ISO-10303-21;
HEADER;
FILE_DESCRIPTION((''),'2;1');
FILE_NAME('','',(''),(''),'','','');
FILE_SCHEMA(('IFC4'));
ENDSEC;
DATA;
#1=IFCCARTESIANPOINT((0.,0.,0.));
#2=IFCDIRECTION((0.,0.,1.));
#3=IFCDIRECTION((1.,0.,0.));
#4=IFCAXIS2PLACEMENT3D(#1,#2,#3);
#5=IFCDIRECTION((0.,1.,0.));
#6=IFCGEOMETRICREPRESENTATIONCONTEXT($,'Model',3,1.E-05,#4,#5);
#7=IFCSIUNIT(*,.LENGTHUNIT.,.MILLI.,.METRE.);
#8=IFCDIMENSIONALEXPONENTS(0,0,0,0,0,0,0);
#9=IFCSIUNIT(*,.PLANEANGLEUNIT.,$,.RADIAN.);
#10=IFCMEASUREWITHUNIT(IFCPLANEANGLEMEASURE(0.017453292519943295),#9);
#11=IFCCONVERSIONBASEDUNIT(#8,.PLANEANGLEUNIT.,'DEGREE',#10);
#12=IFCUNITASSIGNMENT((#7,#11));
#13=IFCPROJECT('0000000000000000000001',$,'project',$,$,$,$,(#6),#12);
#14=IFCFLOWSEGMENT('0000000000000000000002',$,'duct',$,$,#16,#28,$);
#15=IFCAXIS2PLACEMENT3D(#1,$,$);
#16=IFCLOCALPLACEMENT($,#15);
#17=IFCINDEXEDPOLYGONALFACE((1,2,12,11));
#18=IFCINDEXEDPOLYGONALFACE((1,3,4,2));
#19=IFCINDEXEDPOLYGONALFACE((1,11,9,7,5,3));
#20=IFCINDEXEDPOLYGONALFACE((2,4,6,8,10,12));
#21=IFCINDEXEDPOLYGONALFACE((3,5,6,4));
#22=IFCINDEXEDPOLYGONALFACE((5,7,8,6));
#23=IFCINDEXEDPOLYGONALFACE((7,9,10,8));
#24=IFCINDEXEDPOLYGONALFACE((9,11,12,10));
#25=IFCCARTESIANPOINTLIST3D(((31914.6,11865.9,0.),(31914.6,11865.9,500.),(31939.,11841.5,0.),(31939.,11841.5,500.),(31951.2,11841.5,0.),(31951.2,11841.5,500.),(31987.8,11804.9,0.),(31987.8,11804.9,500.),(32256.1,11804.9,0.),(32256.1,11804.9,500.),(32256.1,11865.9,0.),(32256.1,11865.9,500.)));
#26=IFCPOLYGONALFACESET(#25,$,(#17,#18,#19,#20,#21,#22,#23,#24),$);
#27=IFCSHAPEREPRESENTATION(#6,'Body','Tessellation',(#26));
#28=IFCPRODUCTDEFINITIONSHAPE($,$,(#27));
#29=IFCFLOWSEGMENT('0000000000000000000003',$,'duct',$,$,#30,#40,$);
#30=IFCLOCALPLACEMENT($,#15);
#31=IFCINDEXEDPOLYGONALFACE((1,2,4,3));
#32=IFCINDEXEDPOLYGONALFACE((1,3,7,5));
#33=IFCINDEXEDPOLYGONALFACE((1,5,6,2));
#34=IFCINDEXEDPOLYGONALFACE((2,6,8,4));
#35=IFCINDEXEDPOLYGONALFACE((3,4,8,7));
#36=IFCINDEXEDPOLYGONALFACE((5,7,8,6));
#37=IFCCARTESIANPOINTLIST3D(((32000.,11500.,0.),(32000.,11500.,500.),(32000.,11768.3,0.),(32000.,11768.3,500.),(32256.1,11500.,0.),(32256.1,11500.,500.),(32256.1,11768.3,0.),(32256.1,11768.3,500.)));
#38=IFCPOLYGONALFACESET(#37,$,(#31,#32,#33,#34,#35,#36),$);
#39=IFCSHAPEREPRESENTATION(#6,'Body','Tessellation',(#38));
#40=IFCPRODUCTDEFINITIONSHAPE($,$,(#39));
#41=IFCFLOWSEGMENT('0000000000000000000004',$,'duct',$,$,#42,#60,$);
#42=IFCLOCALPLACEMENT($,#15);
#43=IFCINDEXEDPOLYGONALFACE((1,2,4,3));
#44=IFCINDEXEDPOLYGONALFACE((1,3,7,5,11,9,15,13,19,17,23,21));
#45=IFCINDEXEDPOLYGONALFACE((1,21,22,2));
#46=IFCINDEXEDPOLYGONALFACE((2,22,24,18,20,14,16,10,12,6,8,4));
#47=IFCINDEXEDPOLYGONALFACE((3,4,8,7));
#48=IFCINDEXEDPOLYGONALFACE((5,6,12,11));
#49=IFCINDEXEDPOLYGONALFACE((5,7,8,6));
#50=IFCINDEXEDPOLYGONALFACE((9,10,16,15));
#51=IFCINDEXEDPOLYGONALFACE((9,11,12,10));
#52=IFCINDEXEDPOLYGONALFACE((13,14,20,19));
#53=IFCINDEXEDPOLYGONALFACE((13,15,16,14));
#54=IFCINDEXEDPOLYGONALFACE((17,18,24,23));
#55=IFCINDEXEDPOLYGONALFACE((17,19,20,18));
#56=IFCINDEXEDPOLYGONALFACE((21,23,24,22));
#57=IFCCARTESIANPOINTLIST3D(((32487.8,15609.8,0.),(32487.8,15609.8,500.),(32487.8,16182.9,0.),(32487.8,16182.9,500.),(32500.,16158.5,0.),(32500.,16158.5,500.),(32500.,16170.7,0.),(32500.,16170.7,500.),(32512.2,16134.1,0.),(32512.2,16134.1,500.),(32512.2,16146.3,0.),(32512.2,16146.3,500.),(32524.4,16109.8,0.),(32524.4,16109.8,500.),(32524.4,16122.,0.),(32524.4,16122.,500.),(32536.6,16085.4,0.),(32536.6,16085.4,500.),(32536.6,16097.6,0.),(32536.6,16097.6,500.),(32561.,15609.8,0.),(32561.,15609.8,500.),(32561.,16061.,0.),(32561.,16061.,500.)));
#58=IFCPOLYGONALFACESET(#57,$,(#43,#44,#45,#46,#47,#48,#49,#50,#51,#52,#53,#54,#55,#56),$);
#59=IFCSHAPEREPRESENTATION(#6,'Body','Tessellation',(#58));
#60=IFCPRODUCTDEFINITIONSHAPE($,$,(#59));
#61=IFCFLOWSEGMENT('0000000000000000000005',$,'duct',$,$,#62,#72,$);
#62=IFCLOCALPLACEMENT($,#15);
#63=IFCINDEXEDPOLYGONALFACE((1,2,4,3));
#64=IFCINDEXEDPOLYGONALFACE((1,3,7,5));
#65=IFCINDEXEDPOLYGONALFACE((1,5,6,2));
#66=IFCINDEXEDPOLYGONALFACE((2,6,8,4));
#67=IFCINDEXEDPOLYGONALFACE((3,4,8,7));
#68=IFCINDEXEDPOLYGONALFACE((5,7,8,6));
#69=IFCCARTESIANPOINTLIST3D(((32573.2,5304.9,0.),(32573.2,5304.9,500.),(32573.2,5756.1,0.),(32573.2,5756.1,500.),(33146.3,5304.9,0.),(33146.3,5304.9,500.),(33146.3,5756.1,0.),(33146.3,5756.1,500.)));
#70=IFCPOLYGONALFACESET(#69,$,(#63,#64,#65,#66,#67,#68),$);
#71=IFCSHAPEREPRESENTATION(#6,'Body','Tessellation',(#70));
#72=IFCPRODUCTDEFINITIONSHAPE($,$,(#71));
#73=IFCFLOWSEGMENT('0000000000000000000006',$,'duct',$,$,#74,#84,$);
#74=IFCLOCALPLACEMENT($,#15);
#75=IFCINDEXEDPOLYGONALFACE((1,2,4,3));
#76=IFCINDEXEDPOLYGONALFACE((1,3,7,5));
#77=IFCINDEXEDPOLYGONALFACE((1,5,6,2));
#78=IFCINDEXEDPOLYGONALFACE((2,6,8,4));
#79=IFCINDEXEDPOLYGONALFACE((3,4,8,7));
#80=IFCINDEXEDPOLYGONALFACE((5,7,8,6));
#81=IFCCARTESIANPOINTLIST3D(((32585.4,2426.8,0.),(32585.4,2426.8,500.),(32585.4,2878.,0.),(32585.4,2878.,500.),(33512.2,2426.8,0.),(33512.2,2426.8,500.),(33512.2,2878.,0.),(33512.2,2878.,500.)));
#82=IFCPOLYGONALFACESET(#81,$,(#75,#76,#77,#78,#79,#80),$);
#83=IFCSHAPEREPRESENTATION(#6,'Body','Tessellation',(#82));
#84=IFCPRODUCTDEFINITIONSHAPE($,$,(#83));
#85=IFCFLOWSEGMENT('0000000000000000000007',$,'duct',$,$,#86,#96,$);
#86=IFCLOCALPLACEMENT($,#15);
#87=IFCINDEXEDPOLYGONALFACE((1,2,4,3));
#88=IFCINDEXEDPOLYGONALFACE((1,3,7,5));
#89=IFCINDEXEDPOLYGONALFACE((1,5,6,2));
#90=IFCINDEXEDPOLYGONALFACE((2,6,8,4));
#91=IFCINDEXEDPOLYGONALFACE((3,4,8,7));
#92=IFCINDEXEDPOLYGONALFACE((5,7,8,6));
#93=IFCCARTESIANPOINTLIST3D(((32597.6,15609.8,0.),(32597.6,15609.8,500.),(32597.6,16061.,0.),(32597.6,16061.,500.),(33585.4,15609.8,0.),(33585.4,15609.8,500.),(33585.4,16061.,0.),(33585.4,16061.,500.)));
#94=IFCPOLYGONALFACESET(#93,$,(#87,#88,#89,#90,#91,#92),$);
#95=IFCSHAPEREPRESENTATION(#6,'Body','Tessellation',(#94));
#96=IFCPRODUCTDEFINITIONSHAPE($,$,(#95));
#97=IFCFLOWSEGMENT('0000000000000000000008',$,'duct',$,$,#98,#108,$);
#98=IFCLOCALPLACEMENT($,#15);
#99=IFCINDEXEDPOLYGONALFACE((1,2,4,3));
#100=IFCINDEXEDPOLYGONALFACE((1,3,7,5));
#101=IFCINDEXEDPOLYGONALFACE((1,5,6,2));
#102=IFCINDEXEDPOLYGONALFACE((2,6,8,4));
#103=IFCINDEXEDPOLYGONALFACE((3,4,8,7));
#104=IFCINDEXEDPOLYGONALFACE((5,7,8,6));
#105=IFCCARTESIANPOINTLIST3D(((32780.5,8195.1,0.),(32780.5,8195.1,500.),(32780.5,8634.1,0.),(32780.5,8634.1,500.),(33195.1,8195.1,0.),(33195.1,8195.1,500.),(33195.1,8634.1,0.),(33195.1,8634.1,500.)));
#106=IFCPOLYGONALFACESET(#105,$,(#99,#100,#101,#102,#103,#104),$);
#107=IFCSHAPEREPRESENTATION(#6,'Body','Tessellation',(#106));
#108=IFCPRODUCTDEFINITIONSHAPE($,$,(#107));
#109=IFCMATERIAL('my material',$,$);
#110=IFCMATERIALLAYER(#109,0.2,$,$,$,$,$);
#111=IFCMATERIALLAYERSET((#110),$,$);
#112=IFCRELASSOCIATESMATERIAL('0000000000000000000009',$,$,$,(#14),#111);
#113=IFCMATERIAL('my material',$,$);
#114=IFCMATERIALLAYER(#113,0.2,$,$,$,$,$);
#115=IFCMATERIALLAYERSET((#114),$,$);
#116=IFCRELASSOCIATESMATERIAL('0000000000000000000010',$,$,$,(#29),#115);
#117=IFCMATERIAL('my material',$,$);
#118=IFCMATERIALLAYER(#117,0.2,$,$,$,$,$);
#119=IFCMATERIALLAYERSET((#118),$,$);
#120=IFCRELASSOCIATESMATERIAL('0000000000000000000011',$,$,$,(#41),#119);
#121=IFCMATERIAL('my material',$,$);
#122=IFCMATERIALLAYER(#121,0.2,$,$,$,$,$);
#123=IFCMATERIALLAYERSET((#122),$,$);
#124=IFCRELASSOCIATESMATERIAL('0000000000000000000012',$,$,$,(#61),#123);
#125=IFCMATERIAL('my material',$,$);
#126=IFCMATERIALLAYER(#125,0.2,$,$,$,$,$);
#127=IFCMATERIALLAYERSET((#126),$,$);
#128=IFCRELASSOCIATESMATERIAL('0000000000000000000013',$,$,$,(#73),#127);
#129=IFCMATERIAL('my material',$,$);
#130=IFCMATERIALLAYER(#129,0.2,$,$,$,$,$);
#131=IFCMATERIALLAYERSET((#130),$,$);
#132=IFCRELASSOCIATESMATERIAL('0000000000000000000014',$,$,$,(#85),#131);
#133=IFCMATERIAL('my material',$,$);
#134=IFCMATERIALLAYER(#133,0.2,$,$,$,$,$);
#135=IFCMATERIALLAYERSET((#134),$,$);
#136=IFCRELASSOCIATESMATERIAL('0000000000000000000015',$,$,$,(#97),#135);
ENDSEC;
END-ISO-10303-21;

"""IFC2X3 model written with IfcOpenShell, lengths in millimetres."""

from ifc_helpers import new_model, entity, si_unit, converted_unit, direction, origin_with_axes, place, context, project, polyline, outline, extrude, material, layer, layer_set, layer_usage, element, save


model = new_model("IFC2X3")

# Units and contexts
model_context = context("Model", 3, precision=1e-05, world=origin_with_axes(), true_north=direction((0.0, 1.0, 0.0)))
ifc_project = project(units=[si_unit("LENGTHUNIT", "METRE", prefix="MILLI"), converted_unit("PLANEANGLEUNIT", "DEGREE", entity("IfcPlaneAngleMeasure", 0.017453292519943295), si_unit("PLANEANGLEUNIT", "RADIAN"), dimensions=[0, 0, 0, 0, 0, 0, 0])], contexts=[model_context])

# Flow segments
ifc_material_1 = material(Name="my material")
ifc_layer_1 = layer(ifc_material_1, 0.2)
ifc_layer_set_1 = layer_set([ifc_layer_1])
ifc_layer_usage_1 = layer_usage(ifc_layer_set_1, "AXIS2", "POSITIVE", -0.1)
flow_segment_1_placement = place(None, origin_with_axes())
element("IfcFlowSegment", 1, at=flow_segment_1_placement, material=ifc_layer_usage_1, Name="duct", context=model_context, shape_type="SweptSolid", body=[
    extrude(outline(polyline([(31914.6, 11865.9), (31939.0, 11841.5), (31951.2, 11841.5), (31987.8, 11804.9), (32256.1, 11804.9), (32256.1, 11865.9), (31914.6, 11865.9)])), origin_with_axes(), (0.0, 0.0, 1.0), 500.0),
])
ifc_material_2 = material(Name="my material")
ifc_layer_2 = layer(ifc_material_2, 0.2)
ifc_layer_set_2 = layer_set([ifc_layer_2])
ifc_layer_usage_2 = layer_usage(ifc_layer_set_2, "AXIS2", "POSITIVE", -0.1)
flow_segment_2_placement = place(None, origin_with_axes())
element("IfcFlowSegment", 2, at=flow_segment_2_placement, material=ifc_layer_usage_2, Name="duct", context=model_context, shape_type="SweptSolid", body=[
    extrude(outline(polyline([(32000.0, 11500.0), (32256.1, 11500.0), (32256.1, 11768.3), (32000.0, 11768.3), (32000.0, 11500.0)])), origin_with_axes(), (0.0, 0.0, 1.0), 500.0),
])
ifc_material_3 = material(Name="my material")
ifc_layer_3 = layer(ifc_material_3, 0.2)
ifc_layer_set_3 = layer_set([ifc_layer_3])
ifc_layer_usage_3 = layer_usage(ifc_layer_set_3, "AXIS2", "POSITIVE", -0.1)
flow_segment_3_placement = place(None, origin_with_axes())
element("IfcFlowSegment", 3, at=flow_segment_3_placement, material=ifc_layer_usage_3, Name="duct", context=model_context, shape_type="SweptSolid", body=[
    extrude(outline(polyline([(32487.8, 15609.8), (32561.0, 15609.8), (32561.0, 16061.0), (32536.6, 16085.4), (32536.6, 16097.6), (32524.4, 16109.8), (32524.4, 16122.0), (32512.2, 16134.1), (32512.2, 16146.3), (32500.0, 16158.5), (32500.0, 16170.7), (32487.8, 16182.9), (32487.8, 16195.1), (32487.8, 15609.8)])), origin_with_axes(), (0.0, 0.0, 1.0), 500.0),
])
ifc_material_4 = material(Name="my material")
ifc_layer_4 = layer(ifc_material_4, 0.2)
ifc_layer_set_4 = layer_set([ifc_layer_4])
ifc_layer_usage_4 = layer_usage(ifc_layer_set_4, "AXIS2", "POSITIVE", -0.1)
flow_segment_4_placement = place(None, origin_with_axes())
element("IfcFlowSegment", 4, at=flow_segment_4_placement, material=ifc_layer_usage_4, Name="duct", context=model_context, shape_type="SweptSolid", body=[
    extrude(outline(polyline([(32573.2, 5304.9), (33146.3, 5304.9), (33146.3, 5756.1), (32573.2, 5756.1), (32573.2, 5304.9)])), origin_with_axes(), (0.0, 0.0, 1.0), 500.0),
])
ifc_material_5 = material(Name="my material")
ifc_layer_5 = layer(ifc_material_5, 0.2)
ifc_layer_set_5 = layer_set([ifc_layer_5])
ifc_layer_usage_5 = layer_usage(ifc_layer_set_5, "AXIS2", "POSITIVE", -0.1)
flow_segment_5_placement = place(None, origin_with_axes())
element("IfcFlowSegment", 5, at=flow_segment_5_placement, material=ifc_layer_usage_5, Name="duct", context=model_context, shape_type="SweptSolid", body=[
    extrude(outline(polyline([(32585.4, 2426.8), (33512.2, 2426.8), (33512.2, 2878.0), (32585.4, 2878.0), (32585.4, 2426.8)])), origin_with_axes(), (0.0, 0.0, 1.0), 500.0),
])
ifc_material_6 = material(Name="my material")
ifc_layer_6 = layer(ifc_material_6, 0.2)
ifc_layer_set_6 = layer_set([ifc_layer_6])
ifc_layer_usage_6 = layer_usage(ifc_layer_set_6, "AXIS2", "POSITIVE", -0.1)
flow_segment_6_placement = place(None, origin_with_axes())
element("IfcFlowSegment", 6, at=flow_segment_6_placement, material=ifc_layer_usage_6, Name="duct", context=model_context, shape_type="SweptSolid", body=[
    extrude(outline(polyline([(32597.6, 15609.8), (33585.4, 15609.8), (33585.4, 16061.0), (32597.6, 16061.0), (32597.6, 15609.8)])), origin_with_axes(), (0.0, 0.0, 1.0), 500.0),
])
ifc_material_7 = material(Name="my material")
ifc_layer_7 = layer(ifc_material_7, 0.2)
ifc_layer_set_7 = layer_set([ifc_layer_7])
ifc_layer_usage_7 = layer_usage(ifc_layer_set_7, "AXIS2", "POSITIVE", -0.1)
flow_segment_7_placement = place(None, origin_with_axes())
element("IfcFlowSegment", 7, at=flow_segment_7_placement, material=ifc_layer_usage_7, Name="duct", context=model_context, shape_type="SweptSolid", body=[
    extrude(outline(polyline([(32780.5, 8195.1), (33195.1, 8195.1), (33195.1, 8634.1), (32780.5, 8634.1), (32780.5, 8195.1)])), origin_with_axes(), (0.0, 0.0, 1.0), 500.0),
])

save(model, "model.ifc")
